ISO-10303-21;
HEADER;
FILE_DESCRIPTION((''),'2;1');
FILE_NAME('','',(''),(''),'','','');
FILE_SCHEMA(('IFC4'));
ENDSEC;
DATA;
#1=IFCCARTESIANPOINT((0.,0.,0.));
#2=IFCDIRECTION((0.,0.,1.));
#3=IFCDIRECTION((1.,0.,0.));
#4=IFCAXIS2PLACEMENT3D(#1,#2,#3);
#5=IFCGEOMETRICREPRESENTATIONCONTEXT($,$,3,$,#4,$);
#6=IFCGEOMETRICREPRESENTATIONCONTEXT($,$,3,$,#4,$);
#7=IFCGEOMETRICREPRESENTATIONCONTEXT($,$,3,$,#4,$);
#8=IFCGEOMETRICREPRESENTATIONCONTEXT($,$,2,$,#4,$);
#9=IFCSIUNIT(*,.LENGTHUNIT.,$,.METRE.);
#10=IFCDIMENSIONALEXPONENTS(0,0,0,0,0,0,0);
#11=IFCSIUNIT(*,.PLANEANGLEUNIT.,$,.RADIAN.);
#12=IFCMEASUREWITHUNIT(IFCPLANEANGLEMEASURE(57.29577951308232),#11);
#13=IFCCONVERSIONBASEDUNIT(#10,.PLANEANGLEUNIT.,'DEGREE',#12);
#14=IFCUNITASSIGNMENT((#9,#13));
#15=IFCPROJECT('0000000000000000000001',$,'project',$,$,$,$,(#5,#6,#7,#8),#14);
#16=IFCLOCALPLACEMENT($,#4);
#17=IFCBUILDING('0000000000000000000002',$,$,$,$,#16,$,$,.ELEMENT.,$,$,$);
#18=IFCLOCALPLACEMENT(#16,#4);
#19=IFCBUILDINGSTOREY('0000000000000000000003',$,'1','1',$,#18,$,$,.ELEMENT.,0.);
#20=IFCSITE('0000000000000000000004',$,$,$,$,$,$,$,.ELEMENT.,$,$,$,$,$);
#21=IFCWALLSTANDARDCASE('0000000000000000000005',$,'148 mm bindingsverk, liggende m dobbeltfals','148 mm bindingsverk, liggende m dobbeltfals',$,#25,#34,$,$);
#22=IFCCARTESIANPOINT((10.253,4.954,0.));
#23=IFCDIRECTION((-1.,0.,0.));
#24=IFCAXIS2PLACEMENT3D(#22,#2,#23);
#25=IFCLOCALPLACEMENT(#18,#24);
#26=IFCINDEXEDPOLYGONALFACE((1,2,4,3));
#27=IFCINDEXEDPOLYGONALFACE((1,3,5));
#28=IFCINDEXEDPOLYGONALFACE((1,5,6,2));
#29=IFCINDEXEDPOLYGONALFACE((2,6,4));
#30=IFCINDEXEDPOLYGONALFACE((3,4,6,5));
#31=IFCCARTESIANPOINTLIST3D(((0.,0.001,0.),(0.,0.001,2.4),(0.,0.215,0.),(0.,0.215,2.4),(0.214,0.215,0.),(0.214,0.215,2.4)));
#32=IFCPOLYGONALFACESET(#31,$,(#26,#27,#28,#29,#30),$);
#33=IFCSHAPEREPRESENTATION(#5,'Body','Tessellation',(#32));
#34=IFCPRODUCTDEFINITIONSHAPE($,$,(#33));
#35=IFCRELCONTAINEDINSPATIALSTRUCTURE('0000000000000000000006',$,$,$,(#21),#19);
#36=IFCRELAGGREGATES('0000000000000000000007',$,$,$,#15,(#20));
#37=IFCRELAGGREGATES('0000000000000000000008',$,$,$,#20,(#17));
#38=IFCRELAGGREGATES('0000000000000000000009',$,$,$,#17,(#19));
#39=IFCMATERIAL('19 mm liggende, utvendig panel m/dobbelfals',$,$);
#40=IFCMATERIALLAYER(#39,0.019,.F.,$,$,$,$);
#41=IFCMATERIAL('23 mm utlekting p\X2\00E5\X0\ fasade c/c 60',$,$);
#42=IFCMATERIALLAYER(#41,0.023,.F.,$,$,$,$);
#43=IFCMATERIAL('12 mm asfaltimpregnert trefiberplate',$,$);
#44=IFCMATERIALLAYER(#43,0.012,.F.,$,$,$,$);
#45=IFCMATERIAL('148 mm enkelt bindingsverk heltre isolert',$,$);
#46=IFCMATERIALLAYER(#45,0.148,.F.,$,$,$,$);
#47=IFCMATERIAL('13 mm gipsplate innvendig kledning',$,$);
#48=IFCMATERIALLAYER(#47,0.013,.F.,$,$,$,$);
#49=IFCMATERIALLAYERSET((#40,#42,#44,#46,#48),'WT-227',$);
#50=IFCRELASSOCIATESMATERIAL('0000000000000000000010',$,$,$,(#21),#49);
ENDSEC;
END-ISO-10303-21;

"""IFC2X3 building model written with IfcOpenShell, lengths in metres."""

from ifc_helpers import new_model, entity, si_unit, converted_unit, frame, origin_with_axes, place, context, project, spatial, polyline, outline, extrude, material, layer, layer_set, layer_usage, element, save


model = new_model("IFC2X3")

# Units and contexts
context_of_model_1 = context(None, 3, world=origin_with_axes())
context_of_model_2 = context(None, 3, world=origin_with_axes())
context_of_model_3 = context(None, 3, world=origin_with_axes())
context_of_model_4 = context(None, 2, world=origin_with_axes())
ifc_project = project(units=[si_unit("LENGTHUNIT", "METRE"), converted_unit("PLANEANGLEUNIT", "DEGREE", entity("IfcPlaneAngleMeasure", 57.29577951308232), si_unit("PLANEANGLEUNIT", "RADIAN"), dimensions=[0, 0, 0, 0, 0, 0, 0])], contexts=[context_of_model_1, context_of_model_2, context_of_model_3, context_of_model_4])

# Site, building, storey
site = spatial("IfcSite", under=ifc_project, CompositionType="ELEMENT")
building_placement = place(None, origin_with_axes())
building = spatial("IfcBuilding", under=site, at=building_placement, CompositionType="ELEMENT")
storey_placement = place(building_placement, origin_with_axes())
storey = spatial("IfcBuildingStorey", under=building, at=storey_placement, Name="1", Description="1", CompositionType="ELEMENT", Elevation=0.0)

# Shared definitions
ifc_material_1 = material(Name="19 mm liggende, utvendig panel m/dobbelfals")
ifc_layer_1 = layer(ifc_material_1, 0.019, ventilated=False)
ifc_material_2 = material(Name="23 mm utlekting på fasade c/c 60")
ifc_layer_2 = layer(ifc_material_2, 0.023, ventilated=False)
ifc_material_3 = material(Name="12 mm asfaltimpregnert trefiberplate")
ifc_layer_3 = layer(ifc_material_3, 0.012, ventilated=False)
ifc_material_4 = material(Name="148 mm enkelt bindingsverk heltre isolert")
ifc_layer_4 = layer(ifc_material_4, 0.148, ventilated=False)
ifc_material_5 = material(Name="13 mm gipsplate innvendig kledning")
ifc_layer_5 = layer(ifc_material_5, 0.013, ventilated=False)
ifc_layer_set_1 = layer_set([ifc_layer_1, ifc_layer_2, ifc_layer_3, ifc_layer_4, ifc_layer_5], Name="WT-227")
ifc_layer_usage_1 = layer_usage(ifc_layer_set_1, "AXIS2", "POSITIVE", 0.0)

# Wall
wall_1_placement = place(storey_placement, frame((10.253, 4.954, 0.0), z_axis=(0.0, 0.0, 1.0), x_axis=(-1.0, 0.0, 0.0)))
element("IfcWallStandardCase", 1, at=wall_1_placement, inside=storey, material=ifc_layer_usage_1, Name="148 mm bindingsverk, liggende m dobbeltfals", Description="148 mm bindingsverk, liggende m dobbeltfals", context=context_of_model_1, shape_type="SweptSolid", body=[
    extrude(outline(polyline([(0.0, 0.0), (0.001, 0.0), (-0.214, 0.215), (0.0, 0.215), (0.0, 0.0)])), frame((0.0, 0.0, 0.0), z_axis=(0.0, 0.0, -1.0), x_axis=(-1.0, 0.0, 0.0)), (0.0, 0.0, -1.0), 2.4),
])

save(model, "model.ifc")
